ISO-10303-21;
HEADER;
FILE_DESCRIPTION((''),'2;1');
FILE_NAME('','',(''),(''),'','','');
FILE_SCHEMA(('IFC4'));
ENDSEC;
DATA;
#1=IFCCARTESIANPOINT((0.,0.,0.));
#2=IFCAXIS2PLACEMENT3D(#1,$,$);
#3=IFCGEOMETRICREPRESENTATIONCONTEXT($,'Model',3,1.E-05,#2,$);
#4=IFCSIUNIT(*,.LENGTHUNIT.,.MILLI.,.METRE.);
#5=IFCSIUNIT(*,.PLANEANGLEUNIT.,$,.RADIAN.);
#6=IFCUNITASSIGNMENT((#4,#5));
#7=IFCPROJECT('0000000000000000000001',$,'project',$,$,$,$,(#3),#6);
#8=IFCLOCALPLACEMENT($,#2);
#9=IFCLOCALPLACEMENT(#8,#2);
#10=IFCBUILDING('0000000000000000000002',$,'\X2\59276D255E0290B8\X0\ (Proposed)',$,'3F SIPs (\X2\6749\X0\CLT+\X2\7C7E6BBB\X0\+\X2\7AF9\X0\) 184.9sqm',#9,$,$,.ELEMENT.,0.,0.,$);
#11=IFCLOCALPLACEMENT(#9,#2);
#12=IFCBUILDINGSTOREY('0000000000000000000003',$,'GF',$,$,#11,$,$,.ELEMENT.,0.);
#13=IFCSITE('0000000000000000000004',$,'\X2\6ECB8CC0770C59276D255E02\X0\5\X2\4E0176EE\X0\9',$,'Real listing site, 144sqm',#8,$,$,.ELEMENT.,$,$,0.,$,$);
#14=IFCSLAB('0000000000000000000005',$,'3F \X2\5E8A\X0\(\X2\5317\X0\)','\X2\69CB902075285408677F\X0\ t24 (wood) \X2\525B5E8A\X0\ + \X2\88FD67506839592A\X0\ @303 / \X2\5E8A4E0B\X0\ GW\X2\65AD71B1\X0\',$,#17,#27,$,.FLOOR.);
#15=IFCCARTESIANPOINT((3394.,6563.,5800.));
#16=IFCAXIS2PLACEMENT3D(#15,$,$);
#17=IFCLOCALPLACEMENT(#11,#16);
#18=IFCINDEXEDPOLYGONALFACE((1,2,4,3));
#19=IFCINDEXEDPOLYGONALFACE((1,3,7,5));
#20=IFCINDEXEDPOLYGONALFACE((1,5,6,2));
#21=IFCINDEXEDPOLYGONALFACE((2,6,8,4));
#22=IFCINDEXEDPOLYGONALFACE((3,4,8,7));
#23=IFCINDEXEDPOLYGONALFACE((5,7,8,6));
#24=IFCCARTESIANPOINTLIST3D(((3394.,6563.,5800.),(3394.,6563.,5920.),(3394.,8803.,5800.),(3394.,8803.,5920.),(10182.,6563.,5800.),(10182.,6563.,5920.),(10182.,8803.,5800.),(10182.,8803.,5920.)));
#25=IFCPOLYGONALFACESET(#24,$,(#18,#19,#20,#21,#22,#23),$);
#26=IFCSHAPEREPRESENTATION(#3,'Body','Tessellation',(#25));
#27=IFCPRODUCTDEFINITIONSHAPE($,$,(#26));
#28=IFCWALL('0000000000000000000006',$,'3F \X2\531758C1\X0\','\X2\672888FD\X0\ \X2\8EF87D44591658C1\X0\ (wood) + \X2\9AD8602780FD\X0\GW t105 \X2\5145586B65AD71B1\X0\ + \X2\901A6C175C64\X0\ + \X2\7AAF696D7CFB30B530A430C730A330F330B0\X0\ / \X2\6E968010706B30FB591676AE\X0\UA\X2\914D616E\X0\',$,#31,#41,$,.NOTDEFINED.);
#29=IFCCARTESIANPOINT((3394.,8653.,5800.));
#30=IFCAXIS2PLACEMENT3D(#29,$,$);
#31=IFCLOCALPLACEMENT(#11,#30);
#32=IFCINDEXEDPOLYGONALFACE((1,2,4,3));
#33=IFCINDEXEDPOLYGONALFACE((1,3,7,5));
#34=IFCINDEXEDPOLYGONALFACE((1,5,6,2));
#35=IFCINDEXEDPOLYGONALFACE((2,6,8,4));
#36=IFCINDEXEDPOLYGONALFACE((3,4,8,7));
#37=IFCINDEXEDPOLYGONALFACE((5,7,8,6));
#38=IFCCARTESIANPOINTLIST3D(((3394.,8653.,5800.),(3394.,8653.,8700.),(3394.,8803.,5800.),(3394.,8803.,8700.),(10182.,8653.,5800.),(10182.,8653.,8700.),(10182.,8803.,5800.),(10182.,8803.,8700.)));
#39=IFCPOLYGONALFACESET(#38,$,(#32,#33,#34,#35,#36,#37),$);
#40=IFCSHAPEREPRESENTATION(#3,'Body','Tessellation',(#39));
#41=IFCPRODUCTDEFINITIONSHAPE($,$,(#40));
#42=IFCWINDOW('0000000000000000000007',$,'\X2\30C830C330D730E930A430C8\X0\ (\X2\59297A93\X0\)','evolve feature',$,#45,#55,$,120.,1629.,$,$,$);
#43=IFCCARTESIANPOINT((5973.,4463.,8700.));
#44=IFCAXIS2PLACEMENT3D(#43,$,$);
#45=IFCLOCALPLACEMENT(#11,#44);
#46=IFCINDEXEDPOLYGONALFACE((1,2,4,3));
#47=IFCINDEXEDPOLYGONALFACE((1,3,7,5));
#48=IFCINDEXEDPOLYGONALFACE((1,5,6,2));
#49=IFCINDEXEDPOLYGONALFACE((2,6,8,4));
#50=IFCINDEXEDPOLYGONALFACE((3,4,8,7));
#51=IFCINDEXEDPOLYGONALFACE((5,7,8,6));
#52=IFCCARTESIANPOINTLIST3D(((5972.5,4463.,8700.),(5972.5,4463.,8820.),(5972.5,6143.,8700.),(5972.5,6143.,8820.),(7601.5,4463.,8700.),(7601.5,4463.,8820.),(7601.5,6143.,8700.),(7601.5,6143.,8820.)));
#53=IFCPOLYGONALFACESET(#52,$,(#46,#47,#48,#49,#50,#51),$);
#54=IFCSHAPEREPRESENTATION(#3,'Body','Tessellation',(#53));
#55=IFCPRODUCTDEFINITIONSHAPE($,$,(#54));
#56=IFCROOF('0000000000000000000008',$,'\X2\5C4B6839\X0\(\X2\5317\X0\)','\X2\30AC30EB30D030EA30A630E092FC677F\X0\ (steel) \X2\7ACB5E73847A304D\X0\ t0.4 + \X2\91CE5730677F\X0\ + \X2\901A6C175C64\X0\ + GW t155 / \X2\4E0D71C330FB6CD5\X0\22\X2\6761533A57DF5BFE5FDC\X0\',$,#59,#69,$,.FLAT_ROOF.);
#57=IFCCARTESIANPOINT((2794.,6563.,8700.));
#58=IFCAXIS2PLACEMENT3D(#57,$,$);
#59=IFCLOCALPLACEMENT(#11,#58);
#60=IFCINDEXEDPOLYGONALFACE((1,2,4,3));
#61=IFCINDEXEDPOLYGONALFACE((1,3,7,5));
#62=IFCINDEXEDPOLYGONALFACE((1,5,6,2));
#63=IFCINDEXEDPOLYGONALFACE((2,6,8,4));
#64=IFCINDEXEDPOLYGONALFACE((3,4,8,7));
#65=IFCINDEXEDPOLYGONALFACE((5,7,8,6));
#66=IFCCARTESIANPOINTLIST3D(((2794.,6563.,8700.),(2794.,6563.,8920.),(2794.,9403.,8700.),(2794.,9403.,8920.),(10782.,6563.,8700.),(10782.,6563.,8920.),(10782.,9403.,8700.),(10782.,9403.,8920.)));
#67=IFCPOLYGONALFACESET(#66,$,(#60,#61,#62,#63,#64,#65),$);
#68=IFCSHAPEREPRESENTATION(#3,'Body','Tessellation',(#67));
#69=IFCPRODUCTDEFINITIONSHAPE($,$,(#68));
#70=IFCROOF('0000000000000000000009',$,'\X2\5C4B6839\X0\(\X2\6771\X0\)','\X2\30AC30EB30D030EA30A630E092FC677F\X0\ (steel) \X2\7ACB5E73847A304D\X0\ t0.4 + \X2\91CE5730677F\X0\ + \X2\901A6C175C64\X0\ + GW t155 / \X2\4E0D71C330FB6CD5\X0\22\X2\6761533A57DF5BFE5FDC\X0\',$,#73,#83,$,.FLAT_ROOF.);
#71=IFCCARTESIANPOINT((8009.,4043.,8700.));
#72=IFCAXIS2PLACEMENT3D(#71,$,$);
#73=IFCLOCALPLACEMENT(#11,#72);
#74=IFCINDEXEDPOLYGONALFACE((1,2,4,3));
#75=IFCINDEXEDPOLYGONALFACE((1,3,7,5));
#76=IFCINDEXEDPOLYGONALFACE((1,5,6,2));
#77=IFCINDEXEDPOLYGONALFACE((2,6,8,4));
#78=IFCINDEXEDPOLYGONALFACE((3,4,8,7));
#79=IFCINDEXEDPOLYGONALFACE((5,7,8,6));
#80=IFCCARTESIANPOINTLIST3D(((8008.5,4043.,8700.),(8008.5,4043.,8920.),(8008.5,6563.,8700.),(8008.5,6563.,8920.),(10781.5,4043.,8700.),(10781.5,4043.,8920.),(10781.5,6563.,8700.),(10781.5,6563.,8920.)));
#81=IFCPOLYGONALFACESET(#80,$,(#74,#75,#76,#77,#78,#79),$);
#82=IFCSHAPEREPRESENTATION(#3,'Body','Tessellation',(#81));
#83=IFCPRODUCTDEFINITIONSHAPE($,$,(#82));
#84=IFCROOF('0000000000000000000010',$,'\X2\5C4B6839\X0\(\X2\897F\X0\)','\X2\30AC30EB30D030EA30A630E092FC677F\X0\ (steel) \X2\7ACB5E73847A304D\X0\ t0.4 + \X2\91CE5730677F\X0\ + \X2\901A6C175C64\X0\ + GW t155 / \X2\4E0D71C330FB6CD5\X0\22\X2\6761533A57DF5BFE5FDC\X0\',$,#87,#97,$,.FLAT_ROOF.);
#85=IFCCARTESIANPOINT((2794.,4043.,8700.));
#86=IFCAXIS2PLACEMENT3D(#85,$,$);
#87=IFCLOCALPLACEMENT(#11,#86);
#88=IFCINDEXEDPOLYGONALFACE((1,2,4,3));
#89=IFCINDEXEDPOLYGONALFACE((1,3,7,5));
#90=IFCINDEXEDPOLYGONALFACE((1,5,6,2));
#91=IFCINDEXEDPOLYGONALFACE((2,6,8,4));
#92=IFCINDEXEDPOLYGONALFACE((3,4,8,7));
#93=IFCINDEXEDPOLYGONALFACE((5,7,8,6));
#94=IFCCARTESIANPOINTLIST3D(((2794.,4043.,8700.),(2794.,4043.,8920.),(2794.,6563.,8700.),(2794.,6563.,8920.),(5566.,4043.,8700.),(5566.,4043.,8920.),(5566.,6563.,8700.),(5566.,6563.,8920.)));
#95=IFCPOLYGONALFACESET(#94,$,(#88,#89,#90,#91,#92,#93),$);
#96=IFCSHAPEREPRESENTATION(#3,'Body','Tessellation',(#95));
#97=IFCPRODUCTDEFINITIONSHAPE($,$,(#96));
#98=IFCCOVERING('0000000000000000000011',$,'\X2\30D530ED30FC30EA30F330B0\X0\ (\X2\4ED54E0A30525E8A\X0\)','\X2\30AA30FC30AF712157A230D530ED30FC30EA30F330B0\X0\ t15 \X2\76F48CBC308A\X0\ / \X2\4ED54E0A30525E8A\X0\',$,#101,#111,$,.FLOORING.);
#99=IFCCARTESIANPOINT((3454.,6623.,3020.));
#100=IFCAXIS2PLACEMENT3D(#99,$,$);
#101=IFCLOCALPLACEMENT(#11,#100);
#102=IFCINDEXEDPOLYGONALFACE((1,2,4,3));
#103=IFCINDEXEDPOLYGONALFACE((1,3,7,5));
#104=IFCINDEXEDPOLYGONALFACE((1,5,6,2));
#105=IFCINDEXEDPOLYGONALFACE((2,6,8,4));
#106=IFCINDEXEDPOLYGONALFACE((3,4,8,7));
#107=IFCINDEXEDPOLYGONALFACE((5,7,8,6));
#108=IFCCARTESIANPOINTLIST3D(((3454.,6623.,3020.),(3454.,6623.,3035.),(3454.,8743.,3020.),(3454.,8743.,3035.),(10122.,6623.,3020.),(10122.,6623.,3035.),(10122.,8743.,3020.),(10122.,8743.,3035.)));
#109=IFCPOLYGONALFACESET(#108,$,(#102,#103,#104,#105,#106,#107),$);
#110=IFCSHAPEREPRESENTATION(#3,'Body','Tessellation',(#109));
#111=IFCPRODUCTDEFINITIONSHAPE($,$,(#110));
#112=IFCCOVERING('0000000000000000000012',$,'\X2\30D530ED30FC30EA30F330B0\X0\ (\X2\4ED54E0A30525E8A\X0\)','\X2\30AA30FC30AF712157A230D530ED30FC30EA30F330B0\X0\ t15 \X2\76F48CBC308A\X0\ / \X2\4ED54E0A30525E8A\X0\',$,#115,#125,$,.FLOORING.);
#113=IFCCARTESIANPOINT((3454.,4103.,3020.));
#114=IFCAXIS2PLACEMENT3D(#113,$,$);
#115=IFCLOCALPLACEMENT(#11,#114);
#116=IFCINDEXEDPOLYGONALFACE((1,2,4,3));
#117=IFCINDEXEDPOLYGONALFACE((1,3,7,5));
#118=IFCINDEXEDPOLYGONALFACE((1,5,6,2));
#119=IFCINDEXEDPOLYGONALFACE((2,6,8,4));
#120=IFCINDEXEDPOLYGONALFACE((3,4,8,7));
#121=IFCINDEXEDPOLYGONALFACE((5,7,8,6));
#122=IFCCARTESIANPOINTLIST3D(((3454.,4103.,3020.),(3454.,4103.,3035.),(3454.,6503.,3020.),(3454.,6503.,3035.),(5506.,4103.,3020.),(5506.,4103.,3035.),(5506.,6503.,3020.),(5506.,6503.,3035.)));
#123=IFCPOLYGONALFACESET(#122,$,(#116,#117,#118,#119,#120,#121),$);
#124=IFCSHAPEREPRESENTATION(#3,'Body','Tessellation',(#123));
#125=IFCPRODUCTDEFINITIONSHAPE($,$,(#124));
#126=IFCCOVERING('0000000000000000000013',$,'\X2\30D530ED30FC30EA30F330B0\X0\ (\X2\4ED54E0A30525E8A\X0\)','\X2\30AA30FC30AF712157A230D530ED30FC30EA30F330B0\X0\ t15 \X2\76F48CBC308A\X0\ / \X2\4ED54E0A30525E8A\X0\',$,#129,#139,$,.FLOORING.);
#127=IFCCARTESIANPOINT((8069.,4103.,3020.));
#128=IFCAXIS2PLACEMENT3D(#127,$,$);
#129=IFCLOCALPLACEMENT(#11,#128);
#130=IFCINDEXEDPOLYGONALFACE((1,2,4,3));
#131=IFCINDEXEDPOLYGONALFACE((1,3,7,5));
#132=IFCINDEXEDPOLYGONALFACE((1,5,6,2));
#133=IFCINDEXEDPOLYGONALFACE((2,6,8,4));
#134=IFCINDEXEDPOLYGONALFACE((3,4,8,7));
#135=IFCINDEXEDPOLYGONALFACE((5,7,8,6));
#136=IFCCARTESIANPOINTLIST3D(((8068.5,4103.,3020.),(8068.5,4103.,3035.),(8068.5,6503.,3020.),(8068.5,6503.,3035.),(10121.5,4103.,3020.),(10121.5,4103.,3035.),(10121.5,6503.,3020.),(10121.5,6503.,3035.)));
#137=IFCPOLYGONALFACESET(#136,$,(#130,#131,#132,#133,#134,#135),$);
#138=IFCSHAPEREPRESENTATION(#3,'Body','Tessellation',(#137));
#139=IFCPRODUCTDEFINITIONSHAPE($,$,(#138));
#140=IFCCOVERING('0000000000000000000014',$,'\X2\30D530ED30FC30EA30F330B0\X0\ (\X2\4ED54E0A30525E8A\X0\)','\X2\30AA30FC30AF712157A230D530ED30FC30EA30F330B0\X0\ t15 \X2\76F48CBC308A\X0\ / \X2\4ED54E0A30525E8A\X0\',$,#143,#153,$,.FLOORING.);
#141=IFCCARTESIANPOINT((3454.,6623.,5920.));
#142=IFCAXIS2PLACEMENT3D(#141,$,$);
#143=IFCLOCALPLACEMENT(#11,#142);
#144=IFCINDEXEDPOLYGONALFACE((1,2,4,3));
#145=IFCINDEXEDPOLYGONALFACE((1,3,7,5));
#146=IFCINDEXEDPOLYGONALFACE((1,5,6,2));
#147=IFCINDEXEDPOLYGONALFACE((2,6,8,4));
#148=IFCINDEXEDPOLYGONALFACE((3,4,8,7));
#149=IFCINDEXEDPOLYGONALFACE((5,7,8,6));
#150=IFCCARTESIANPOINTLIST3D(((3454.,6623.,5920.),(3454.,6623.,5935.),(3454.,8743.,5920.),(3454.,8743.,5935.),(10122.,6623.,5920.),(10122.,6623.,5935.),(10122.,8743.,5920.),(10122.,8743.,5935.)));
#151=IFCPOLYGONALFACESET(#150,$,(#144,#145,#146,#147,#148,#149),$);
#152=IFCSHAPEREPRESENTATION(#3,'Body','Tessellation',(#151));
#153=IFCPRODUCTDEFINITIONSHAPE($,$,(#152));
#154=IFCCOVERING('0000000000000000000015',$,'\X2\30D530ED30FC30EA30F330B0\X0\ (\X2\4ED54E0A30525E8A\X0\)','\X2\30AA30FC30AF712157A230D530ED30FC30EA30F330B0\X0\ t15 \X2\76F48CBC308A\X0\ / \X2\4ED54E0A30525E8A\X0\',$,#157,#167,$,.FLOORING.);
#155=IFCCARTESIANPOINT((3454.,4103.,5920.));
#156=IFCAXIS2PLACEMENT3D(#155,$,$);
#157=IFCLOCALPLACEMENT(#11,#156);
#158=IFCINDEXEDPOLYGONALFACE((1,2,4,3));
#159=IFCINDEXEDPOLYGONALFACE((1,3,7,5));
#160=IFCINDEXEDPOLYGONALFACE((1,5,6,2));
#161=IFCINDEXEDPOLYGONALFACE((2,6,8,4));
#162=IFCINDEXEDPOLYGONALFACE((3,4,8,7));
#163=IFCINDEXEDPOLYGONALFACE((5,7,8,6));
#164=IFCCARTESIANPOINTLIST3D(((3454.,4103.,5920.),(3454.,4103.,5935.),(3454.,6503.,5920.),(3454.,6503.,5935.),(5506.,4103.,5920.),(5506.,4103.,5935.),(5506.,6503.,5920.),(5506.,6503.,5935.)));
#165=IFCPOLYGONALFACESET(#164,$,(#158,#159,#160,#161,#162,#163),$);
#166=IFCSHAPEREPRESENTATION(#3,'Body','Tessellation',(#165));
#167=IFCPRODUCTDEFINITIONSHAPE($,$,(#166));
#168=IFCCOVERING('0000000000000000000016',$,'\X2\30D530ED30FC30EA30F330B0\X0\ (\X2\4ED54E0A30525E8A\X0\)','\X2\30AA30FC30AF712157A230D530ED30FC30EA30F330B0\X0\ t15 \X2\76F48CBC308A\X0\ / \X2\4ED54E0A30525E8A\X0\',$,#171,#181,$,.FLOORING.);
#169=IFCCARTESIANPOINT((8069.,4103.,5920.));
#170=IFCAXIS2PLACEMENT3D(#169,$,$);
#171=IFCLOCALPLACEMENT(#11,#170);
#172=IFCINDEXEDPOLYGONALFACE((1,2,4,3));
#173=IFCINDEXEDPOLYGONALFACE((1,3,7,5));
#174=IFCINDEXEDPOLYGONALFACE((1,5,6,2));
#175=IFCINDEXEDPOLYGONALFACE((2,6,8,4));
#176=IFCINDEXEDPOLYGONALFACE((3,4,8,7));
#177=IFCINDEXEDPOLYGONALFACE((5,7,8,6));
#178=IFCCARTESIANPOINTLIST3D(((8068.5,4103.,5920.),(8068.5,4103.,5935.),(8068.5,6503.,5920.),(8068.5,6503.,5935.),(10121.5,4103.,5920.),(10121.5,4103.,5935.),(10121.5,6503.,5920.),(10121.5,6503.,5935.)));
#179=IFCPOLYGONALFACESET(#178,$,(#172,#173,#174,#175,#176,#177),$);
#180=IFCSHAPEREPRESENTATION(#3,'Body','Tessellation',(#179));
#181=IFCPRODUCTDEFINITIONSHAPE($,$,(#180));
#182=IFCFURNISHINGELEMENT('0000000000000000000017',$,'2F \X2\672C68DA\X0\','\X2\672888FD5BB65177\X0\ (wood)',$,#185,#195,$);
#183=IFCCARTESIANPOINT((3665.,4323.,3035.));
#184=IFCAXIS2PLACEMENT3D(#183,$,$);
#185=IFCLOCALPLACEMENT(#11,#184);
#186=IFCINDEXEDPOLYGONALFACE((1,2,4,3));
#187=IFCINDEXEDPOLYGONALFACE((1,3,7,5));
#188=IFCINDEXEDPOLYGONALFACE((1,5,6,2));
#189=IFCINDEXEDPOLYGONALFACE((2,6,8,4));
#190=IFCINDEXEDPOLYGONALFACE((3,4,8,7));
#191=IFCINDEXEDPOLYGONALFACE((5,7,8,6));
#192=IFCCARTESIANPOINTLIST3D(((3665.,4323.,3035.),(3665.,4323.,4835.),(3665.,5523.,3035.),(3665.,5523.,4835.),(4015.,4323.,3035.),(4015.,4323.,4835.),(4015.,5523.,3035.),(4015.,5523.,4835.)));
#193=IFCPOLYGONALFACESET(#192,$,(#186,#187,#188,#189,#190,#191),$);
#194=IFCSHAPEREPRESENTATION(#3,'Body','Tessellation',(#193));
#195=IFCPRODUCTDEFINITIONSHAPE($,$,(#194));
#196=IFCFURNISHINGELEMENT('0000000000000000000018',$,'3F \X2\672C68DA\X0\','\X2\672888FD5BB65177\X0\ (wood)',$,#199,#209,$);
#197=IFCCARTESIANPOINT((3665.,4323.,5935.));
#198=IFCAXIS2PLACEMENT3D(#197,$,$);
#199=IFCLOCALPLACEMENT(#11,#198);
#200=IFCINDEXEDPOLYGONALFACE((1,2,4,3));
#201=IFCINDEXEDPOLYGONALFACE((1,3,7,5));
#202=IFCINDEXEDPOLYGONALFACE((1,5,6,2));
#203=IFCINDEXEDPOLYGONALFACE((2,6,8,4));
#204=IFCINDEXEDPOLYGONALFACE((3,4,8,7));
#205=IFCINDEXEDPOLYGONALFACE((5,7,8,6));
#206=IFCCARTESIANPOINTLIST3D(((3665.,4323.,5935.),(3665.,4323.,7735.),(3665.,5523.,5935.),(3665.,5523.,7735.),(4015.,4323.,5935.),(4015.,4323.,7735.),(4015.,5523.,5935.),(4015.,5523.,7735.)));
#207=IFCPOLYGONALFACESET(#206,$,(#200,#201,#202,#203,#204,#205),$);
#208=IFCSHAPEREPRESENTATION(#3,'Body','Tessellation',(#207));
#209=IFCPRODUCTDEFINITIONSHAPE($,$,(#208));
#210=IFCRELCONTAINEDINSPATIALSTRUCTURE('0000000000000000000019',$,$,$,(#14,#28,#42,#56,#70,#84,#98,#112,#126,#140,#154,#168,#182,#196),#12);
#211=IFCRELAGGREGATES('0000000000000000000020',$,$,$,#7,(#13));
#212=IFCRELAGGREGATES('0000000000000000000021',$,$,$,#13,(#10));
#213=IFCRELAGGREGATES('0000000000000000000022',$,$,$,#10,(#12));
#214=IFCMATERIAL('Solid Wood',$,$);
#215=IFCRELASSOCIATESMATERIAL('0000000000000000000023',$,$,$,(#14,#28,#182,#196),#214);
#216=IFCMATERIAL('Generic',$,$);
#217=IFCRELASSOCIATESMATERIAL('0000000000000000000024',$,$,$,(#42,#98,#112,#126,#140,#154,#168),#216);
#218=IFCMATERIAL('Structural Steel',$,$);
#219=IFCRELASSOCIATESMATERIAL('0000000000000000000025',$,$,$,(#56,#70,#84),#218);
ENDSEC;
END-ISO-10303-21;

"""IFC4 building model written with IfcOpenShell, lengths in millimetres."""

from ifc_helpers import new_model, si_unit, frame, frame_2d, origin, place, context, project, spatial, rectangle, extrude, material, element, save


model = new_model("IFC4")

# Units and contexts
model_context = context("Model", 3, precision=1e-05, world=origin())
ifc_project = project(units=[si_unit("LENGTHUNIT", "METRE", prefix="MILLI"), si_unit("PLANEANGLEUNIT", "RADIAN")], contexts=[model_context])

# Site, building, storey
site_placement = place(None, origin())
site = spatial("IfcSite", under=ifc_project, at=site_placement, Name="滋賀県大津市5丁目9", ObjectType="Real listing site, 144sqm", CompositionType="ELEMENT", RefElevation=0.0)
building_placement = place(site_placement, origin())
building = spatial("IfcBuilding", under=site, at=building_placement, Name="大津市邸 (Proposed)", ObjectType="3F SIPs (杉CLT+籾殻+竹) 184.9sqm", CompositionType="ELEMENT", ElevationOfRefHeight=0.0, ElevationOfTerrain=0.0)
storey_placement = place(building_placement, origin())
storey = spatial("IfcBuildingStorey", under=building, at=storey_placement, Name="GF", CompositionType="ELEMENT", Elevation=0.0)

# Slab
ifc_material_1 = material(Name="Solid Wood")
slab_placement = place(storey_placement, frame((3394.0, 6563.0, 5800.0)))
element("IfcSlab", 1, at=slab_placement, inside=storey, material=ifc_material_1, Name="3F 床(北)", Description="構造用合板 t24 (wood) 剛床 + 製材根太 @303 / 床下 GW断熱", PredefinedType="FLOOR", context=model_context, shape_type="SweptSolid", body=[
    extrude(rectangle(XDim=6788.0, YDim=2240.0, at=frame_2d((3394.0, 1120.0))), frame((3394.0, 6563.0, 5800.0)), (0.0, 0.0, 1.0), 120.0),
])

# Wall
wall_1_placement = place(storey_placement, frame((3394.0, 8653.0, 5800.0)))
element("IfcWall", 2, at=wall_1_placement, inside=storey, material=ifc_material_1, Name="3F 北壁", Description="木製 軸組外壁 (wood) + 高性能GW t105 充填断熱 + 通気層 + 窯業系サイディング / 準耐火・外皮UA配慮", PredefinedType="NOTDEFINED", context=model_context, shape_type="SweptSolid", body=[
    extrude(rectangle(XDim=6788.0, YDim=150.0, at=frame_2d((3394.0, 75.0))), frame((3394.0, 8653.0, 5800.0)), (0.0, 0.0, 1.0), 2900.0),
])

# Window
ifc_material_2 = material(Name="Generic")
window_1_placement = place(storey_placement, frame((5973.0, 4463.0, 8700.0)))
element("IfcWindow", 3, at=window_1_placement, inside=storey, material=ifc_material_2, Name="トップライト (天窓)", Description="evolve feature", OverallHeight=120.0, OverallWidth=1629.0, context=model_context, shape_type="SweptSolid", body=[
    extrude(rectangle(XDim=1629.0, YDim=1680.0, at=frame_2d((814.0, 840.0))), frame((5973.0, 4463.0, 8700.0)), (0.0, 0.0, 1.0), 120.0),
])

# Roofs
ifc_material_3 = material(Name="Structural Steel")
roof_1_placement = place(storey_placement, frame((2794.0, 6563.0, 8700.0)))
element("IfcRoof", 4, at=roof_1_placement, inside=storey, material=ifc_material_3, Name="屋根(北)", Description="ガルバリウム鋼板 (steel) 立平葺き t0.4 + 野地板 + 通気層 + GW t155 / 不燃・法22条区域対応", PredefinedType="FLAT_ROOF", context=model_context, shape_type="SweptSolid", body=[
    extrude(rectangle(XDim=7988.0, YDim=2840.0, at=frame_2d((3994.0, 1420.0))), frame((2794.0, 6563.0, 8700.0)), (0.0, 0.0, 1.0), 220.0),
])
roof_2_placement = place(storey_placement, frame((8009.0, 4043.0, 8700.0)))
element("IfcRoof", 5, at=roof_2_placement, inside=storey, material=ifc_material_3, Name="屋根(東)", Description="ガルバリウム鋼板 (steel) 立平葺き t0.4 + 野地板 + 通気層 + GW t155 / 不燃・法22条区域対応", PredefinedType="FLAT_ROOF", context=model_context, shape_type="SweptSolid", body=[
    extrude(rectangle(XDim=2773.0, YDim=2520.0, at=frame_2d((1386.0, 1260.0))), frame((8009.0, 4043.0, 8700.0)), (0.0, 0.0, 1.0), 220.0),
])
roof_3_placement = place(storey_placement, frame((2794.0, 4043.0, 8700.0)))
element("IfcRoof", 6, at=roof_3_placement, inside=storey, material=ifc_material_3, Name="屋根(西)", Description="ガルバリウム鋼板 (steel) 立平葺き t0.4 + 野地板 + 通気層 + GW t155 / 不燃・法22条区域対応", PredefinedType="FLAT_ROOF", context=model_context, shape_type="SweptSolid", body=[
    extrude(rectangle(XDim=2772.0, YDim=2520.0, at=frame_2d((1386.0, 1260.0))), frame((2794.0, 4043.0, 8700.0)), (0.0, 0.0, 1.0), 220.0),
])

# Coverings
covering_1_placement = place(storey_placement, frame((3454.0, 6623.0, 3020.0)))
element("IfcCovering", 7, at=covering_1_placement, inside=storey, material=ifc_material_2, Name="フローリング (仕上げ床)", Description="オーク無垢フローリング t15 直貼り / 仕上げ床", PredefinedType="FLOORING", context=model_context, shape_type="SweptSolid", body=[
    extrude(rectangle(XDim=6668.0, YDim=2120.0, at=frame_2d((3334.0, 1060.0))), frame((3454.0, 6623.0, 3020.0)), (0.0, 0.0, 1.0), 15.0),
])
covering_2_placement = place(storey_placement, frame((3454.0, 4103.0, 3020.0)))
element("IfcCovering", 8, at=covering_2_placement, inside=storey, material=ifc_material_2, Name="フローリング (仕上げ床)", Description="オーク無垢フローリング t15 直貼り / 仕上げ床", PredefinedType="FLOORING", context=model_context, shape_type="SweptSolid", body=[
    extrude(rectangle(XDim=2052.0, YDim=2400.0, at=frame_2d((1026.0, 1200.0))), frame((3454.0, 4103.0, 3020.0)), (0.0, 0.0, 1.0), 15.0),
])
covering_3_placement = place(storey_placement, frame((8069.0, 4103.0, 3020.0)))
element("IfcCovering", 9, at=covering_3_placement, inside=storey, material=ifc_material_2, Name="フローリング (仕上げ床)", Description="オーク無垢フローリング t15 直貼り / 仕上げ床", PredefinedType="FLOORING", context=model_context, shape_type="SweptSolid", body=[
    extrude(rectangle(XDim=2053.0, YDim=2400.0, at=frame_2d((1026.0, 1200.0))), frame((8069.0, 4103.0, 3020.0)), (0.0, 0.0, 1.0), 15.0),
])
covering_4_placement = place(storey_placement, frame((3454.0, 6623.0, 5920.0)))
element("IfcCovering", 10, at=covering_4_placement, inside=storey, material=ifc_material_2, Name="フローリング (仕上げ床)", Description="オーク無垢フローリング t15 直貼り / 仕上げ床", PredefinedType="FLOORING", context=model_context, shape_type="SweptSolid", body=[
    extrude(rectangle(XDim=6668.0, YDim=2120.0, at=frame_2d((3334.0, 1060.0))), frame((3454.0, 6623.0, 5920.0)), (0.0, 0.0, 1.0), 15.0),
])
covering_5_placement = place(storey_placement, frame((3454.0, 4103.0, 5920.0)))
element("IfcCovering", 11, at=covering_5_placement, inside=storey, material=ifc_material_2, Name="フローリング (仕上げ床)", Description="オーク無垢フローリング t15 直貼り / 仕上げ床", PredefinedType="FLOORING", context=model_context, shape_type="SweptSolid", body=[
    extrude(rectangle(XDim=2052.0, YDim=2400.0, at=frame_2d((1026.0, 1200.0))), frame((3454.0, 4103.0, 5920.0)), (0.0, 0.0, 1.0), 15.0),
])
covering_6_placement = place(storey_placement, frame((8069.0, 4103.0, 5920.0)))
element("IfcCovering", 12, at=covering_6_placement, inside=storey, material=ifc_material_2, Name="フローリング (仕上げ床)", Description="オーク無垢フローリング t15 直貼り / 仕上げ床", PredefinedType="FLOORING", context=model_context, shape_type="SweptSolid", body=[
    extrude(rectangle(XDim=2053.0, YDim=2400.0, at=frame_2d((1026.0, 1200.0))), frame((8069.0, 4103.0, 5920.0)), (0.0, 0.0, 1.0), 15.0),
])

# Furnishing elements
furnishing_1_placement = place(storey_placement, frame((3665.0, 4323.0, 3035.0)))
element("IfcFurnishingElement", 13, at=furnishing_1_placement, inside=storey, material=ifc_material_1, Name="2F 本棚", Description="木製家具 (wood)", context=model_context, shape_type="SweptSolid", body=[
    extrude(rectangle(XDim=350.0, YDim=1200.0, at=frame_2d((175.0, 600.0))), frame((3665.0, 4323.0, 3035.0)), (0.0, 0.0, 1.0), 1800.0),
])
furnishing_2_placement = place(storey_placement, frame((3665.0, 4323.0, 5935.0)))
element("IfcFurnishingElement", 14, at=furnishing_2_placement, inside=storey, material=ifc_material_1, Name="3F 本棚", Description="木製家具 (wood)", context=model_context, shape_type="SweptSolid", body=[
    extrude(rectangle(XDim=350.0, YDim=1200.0, at=frame_2d((175.0, 600.0))), frame((3665.0, 4323.0, 5935.0)), (0.0, 0.0, 1.0), 1800.0),
])

save(model, "model.ifc")
